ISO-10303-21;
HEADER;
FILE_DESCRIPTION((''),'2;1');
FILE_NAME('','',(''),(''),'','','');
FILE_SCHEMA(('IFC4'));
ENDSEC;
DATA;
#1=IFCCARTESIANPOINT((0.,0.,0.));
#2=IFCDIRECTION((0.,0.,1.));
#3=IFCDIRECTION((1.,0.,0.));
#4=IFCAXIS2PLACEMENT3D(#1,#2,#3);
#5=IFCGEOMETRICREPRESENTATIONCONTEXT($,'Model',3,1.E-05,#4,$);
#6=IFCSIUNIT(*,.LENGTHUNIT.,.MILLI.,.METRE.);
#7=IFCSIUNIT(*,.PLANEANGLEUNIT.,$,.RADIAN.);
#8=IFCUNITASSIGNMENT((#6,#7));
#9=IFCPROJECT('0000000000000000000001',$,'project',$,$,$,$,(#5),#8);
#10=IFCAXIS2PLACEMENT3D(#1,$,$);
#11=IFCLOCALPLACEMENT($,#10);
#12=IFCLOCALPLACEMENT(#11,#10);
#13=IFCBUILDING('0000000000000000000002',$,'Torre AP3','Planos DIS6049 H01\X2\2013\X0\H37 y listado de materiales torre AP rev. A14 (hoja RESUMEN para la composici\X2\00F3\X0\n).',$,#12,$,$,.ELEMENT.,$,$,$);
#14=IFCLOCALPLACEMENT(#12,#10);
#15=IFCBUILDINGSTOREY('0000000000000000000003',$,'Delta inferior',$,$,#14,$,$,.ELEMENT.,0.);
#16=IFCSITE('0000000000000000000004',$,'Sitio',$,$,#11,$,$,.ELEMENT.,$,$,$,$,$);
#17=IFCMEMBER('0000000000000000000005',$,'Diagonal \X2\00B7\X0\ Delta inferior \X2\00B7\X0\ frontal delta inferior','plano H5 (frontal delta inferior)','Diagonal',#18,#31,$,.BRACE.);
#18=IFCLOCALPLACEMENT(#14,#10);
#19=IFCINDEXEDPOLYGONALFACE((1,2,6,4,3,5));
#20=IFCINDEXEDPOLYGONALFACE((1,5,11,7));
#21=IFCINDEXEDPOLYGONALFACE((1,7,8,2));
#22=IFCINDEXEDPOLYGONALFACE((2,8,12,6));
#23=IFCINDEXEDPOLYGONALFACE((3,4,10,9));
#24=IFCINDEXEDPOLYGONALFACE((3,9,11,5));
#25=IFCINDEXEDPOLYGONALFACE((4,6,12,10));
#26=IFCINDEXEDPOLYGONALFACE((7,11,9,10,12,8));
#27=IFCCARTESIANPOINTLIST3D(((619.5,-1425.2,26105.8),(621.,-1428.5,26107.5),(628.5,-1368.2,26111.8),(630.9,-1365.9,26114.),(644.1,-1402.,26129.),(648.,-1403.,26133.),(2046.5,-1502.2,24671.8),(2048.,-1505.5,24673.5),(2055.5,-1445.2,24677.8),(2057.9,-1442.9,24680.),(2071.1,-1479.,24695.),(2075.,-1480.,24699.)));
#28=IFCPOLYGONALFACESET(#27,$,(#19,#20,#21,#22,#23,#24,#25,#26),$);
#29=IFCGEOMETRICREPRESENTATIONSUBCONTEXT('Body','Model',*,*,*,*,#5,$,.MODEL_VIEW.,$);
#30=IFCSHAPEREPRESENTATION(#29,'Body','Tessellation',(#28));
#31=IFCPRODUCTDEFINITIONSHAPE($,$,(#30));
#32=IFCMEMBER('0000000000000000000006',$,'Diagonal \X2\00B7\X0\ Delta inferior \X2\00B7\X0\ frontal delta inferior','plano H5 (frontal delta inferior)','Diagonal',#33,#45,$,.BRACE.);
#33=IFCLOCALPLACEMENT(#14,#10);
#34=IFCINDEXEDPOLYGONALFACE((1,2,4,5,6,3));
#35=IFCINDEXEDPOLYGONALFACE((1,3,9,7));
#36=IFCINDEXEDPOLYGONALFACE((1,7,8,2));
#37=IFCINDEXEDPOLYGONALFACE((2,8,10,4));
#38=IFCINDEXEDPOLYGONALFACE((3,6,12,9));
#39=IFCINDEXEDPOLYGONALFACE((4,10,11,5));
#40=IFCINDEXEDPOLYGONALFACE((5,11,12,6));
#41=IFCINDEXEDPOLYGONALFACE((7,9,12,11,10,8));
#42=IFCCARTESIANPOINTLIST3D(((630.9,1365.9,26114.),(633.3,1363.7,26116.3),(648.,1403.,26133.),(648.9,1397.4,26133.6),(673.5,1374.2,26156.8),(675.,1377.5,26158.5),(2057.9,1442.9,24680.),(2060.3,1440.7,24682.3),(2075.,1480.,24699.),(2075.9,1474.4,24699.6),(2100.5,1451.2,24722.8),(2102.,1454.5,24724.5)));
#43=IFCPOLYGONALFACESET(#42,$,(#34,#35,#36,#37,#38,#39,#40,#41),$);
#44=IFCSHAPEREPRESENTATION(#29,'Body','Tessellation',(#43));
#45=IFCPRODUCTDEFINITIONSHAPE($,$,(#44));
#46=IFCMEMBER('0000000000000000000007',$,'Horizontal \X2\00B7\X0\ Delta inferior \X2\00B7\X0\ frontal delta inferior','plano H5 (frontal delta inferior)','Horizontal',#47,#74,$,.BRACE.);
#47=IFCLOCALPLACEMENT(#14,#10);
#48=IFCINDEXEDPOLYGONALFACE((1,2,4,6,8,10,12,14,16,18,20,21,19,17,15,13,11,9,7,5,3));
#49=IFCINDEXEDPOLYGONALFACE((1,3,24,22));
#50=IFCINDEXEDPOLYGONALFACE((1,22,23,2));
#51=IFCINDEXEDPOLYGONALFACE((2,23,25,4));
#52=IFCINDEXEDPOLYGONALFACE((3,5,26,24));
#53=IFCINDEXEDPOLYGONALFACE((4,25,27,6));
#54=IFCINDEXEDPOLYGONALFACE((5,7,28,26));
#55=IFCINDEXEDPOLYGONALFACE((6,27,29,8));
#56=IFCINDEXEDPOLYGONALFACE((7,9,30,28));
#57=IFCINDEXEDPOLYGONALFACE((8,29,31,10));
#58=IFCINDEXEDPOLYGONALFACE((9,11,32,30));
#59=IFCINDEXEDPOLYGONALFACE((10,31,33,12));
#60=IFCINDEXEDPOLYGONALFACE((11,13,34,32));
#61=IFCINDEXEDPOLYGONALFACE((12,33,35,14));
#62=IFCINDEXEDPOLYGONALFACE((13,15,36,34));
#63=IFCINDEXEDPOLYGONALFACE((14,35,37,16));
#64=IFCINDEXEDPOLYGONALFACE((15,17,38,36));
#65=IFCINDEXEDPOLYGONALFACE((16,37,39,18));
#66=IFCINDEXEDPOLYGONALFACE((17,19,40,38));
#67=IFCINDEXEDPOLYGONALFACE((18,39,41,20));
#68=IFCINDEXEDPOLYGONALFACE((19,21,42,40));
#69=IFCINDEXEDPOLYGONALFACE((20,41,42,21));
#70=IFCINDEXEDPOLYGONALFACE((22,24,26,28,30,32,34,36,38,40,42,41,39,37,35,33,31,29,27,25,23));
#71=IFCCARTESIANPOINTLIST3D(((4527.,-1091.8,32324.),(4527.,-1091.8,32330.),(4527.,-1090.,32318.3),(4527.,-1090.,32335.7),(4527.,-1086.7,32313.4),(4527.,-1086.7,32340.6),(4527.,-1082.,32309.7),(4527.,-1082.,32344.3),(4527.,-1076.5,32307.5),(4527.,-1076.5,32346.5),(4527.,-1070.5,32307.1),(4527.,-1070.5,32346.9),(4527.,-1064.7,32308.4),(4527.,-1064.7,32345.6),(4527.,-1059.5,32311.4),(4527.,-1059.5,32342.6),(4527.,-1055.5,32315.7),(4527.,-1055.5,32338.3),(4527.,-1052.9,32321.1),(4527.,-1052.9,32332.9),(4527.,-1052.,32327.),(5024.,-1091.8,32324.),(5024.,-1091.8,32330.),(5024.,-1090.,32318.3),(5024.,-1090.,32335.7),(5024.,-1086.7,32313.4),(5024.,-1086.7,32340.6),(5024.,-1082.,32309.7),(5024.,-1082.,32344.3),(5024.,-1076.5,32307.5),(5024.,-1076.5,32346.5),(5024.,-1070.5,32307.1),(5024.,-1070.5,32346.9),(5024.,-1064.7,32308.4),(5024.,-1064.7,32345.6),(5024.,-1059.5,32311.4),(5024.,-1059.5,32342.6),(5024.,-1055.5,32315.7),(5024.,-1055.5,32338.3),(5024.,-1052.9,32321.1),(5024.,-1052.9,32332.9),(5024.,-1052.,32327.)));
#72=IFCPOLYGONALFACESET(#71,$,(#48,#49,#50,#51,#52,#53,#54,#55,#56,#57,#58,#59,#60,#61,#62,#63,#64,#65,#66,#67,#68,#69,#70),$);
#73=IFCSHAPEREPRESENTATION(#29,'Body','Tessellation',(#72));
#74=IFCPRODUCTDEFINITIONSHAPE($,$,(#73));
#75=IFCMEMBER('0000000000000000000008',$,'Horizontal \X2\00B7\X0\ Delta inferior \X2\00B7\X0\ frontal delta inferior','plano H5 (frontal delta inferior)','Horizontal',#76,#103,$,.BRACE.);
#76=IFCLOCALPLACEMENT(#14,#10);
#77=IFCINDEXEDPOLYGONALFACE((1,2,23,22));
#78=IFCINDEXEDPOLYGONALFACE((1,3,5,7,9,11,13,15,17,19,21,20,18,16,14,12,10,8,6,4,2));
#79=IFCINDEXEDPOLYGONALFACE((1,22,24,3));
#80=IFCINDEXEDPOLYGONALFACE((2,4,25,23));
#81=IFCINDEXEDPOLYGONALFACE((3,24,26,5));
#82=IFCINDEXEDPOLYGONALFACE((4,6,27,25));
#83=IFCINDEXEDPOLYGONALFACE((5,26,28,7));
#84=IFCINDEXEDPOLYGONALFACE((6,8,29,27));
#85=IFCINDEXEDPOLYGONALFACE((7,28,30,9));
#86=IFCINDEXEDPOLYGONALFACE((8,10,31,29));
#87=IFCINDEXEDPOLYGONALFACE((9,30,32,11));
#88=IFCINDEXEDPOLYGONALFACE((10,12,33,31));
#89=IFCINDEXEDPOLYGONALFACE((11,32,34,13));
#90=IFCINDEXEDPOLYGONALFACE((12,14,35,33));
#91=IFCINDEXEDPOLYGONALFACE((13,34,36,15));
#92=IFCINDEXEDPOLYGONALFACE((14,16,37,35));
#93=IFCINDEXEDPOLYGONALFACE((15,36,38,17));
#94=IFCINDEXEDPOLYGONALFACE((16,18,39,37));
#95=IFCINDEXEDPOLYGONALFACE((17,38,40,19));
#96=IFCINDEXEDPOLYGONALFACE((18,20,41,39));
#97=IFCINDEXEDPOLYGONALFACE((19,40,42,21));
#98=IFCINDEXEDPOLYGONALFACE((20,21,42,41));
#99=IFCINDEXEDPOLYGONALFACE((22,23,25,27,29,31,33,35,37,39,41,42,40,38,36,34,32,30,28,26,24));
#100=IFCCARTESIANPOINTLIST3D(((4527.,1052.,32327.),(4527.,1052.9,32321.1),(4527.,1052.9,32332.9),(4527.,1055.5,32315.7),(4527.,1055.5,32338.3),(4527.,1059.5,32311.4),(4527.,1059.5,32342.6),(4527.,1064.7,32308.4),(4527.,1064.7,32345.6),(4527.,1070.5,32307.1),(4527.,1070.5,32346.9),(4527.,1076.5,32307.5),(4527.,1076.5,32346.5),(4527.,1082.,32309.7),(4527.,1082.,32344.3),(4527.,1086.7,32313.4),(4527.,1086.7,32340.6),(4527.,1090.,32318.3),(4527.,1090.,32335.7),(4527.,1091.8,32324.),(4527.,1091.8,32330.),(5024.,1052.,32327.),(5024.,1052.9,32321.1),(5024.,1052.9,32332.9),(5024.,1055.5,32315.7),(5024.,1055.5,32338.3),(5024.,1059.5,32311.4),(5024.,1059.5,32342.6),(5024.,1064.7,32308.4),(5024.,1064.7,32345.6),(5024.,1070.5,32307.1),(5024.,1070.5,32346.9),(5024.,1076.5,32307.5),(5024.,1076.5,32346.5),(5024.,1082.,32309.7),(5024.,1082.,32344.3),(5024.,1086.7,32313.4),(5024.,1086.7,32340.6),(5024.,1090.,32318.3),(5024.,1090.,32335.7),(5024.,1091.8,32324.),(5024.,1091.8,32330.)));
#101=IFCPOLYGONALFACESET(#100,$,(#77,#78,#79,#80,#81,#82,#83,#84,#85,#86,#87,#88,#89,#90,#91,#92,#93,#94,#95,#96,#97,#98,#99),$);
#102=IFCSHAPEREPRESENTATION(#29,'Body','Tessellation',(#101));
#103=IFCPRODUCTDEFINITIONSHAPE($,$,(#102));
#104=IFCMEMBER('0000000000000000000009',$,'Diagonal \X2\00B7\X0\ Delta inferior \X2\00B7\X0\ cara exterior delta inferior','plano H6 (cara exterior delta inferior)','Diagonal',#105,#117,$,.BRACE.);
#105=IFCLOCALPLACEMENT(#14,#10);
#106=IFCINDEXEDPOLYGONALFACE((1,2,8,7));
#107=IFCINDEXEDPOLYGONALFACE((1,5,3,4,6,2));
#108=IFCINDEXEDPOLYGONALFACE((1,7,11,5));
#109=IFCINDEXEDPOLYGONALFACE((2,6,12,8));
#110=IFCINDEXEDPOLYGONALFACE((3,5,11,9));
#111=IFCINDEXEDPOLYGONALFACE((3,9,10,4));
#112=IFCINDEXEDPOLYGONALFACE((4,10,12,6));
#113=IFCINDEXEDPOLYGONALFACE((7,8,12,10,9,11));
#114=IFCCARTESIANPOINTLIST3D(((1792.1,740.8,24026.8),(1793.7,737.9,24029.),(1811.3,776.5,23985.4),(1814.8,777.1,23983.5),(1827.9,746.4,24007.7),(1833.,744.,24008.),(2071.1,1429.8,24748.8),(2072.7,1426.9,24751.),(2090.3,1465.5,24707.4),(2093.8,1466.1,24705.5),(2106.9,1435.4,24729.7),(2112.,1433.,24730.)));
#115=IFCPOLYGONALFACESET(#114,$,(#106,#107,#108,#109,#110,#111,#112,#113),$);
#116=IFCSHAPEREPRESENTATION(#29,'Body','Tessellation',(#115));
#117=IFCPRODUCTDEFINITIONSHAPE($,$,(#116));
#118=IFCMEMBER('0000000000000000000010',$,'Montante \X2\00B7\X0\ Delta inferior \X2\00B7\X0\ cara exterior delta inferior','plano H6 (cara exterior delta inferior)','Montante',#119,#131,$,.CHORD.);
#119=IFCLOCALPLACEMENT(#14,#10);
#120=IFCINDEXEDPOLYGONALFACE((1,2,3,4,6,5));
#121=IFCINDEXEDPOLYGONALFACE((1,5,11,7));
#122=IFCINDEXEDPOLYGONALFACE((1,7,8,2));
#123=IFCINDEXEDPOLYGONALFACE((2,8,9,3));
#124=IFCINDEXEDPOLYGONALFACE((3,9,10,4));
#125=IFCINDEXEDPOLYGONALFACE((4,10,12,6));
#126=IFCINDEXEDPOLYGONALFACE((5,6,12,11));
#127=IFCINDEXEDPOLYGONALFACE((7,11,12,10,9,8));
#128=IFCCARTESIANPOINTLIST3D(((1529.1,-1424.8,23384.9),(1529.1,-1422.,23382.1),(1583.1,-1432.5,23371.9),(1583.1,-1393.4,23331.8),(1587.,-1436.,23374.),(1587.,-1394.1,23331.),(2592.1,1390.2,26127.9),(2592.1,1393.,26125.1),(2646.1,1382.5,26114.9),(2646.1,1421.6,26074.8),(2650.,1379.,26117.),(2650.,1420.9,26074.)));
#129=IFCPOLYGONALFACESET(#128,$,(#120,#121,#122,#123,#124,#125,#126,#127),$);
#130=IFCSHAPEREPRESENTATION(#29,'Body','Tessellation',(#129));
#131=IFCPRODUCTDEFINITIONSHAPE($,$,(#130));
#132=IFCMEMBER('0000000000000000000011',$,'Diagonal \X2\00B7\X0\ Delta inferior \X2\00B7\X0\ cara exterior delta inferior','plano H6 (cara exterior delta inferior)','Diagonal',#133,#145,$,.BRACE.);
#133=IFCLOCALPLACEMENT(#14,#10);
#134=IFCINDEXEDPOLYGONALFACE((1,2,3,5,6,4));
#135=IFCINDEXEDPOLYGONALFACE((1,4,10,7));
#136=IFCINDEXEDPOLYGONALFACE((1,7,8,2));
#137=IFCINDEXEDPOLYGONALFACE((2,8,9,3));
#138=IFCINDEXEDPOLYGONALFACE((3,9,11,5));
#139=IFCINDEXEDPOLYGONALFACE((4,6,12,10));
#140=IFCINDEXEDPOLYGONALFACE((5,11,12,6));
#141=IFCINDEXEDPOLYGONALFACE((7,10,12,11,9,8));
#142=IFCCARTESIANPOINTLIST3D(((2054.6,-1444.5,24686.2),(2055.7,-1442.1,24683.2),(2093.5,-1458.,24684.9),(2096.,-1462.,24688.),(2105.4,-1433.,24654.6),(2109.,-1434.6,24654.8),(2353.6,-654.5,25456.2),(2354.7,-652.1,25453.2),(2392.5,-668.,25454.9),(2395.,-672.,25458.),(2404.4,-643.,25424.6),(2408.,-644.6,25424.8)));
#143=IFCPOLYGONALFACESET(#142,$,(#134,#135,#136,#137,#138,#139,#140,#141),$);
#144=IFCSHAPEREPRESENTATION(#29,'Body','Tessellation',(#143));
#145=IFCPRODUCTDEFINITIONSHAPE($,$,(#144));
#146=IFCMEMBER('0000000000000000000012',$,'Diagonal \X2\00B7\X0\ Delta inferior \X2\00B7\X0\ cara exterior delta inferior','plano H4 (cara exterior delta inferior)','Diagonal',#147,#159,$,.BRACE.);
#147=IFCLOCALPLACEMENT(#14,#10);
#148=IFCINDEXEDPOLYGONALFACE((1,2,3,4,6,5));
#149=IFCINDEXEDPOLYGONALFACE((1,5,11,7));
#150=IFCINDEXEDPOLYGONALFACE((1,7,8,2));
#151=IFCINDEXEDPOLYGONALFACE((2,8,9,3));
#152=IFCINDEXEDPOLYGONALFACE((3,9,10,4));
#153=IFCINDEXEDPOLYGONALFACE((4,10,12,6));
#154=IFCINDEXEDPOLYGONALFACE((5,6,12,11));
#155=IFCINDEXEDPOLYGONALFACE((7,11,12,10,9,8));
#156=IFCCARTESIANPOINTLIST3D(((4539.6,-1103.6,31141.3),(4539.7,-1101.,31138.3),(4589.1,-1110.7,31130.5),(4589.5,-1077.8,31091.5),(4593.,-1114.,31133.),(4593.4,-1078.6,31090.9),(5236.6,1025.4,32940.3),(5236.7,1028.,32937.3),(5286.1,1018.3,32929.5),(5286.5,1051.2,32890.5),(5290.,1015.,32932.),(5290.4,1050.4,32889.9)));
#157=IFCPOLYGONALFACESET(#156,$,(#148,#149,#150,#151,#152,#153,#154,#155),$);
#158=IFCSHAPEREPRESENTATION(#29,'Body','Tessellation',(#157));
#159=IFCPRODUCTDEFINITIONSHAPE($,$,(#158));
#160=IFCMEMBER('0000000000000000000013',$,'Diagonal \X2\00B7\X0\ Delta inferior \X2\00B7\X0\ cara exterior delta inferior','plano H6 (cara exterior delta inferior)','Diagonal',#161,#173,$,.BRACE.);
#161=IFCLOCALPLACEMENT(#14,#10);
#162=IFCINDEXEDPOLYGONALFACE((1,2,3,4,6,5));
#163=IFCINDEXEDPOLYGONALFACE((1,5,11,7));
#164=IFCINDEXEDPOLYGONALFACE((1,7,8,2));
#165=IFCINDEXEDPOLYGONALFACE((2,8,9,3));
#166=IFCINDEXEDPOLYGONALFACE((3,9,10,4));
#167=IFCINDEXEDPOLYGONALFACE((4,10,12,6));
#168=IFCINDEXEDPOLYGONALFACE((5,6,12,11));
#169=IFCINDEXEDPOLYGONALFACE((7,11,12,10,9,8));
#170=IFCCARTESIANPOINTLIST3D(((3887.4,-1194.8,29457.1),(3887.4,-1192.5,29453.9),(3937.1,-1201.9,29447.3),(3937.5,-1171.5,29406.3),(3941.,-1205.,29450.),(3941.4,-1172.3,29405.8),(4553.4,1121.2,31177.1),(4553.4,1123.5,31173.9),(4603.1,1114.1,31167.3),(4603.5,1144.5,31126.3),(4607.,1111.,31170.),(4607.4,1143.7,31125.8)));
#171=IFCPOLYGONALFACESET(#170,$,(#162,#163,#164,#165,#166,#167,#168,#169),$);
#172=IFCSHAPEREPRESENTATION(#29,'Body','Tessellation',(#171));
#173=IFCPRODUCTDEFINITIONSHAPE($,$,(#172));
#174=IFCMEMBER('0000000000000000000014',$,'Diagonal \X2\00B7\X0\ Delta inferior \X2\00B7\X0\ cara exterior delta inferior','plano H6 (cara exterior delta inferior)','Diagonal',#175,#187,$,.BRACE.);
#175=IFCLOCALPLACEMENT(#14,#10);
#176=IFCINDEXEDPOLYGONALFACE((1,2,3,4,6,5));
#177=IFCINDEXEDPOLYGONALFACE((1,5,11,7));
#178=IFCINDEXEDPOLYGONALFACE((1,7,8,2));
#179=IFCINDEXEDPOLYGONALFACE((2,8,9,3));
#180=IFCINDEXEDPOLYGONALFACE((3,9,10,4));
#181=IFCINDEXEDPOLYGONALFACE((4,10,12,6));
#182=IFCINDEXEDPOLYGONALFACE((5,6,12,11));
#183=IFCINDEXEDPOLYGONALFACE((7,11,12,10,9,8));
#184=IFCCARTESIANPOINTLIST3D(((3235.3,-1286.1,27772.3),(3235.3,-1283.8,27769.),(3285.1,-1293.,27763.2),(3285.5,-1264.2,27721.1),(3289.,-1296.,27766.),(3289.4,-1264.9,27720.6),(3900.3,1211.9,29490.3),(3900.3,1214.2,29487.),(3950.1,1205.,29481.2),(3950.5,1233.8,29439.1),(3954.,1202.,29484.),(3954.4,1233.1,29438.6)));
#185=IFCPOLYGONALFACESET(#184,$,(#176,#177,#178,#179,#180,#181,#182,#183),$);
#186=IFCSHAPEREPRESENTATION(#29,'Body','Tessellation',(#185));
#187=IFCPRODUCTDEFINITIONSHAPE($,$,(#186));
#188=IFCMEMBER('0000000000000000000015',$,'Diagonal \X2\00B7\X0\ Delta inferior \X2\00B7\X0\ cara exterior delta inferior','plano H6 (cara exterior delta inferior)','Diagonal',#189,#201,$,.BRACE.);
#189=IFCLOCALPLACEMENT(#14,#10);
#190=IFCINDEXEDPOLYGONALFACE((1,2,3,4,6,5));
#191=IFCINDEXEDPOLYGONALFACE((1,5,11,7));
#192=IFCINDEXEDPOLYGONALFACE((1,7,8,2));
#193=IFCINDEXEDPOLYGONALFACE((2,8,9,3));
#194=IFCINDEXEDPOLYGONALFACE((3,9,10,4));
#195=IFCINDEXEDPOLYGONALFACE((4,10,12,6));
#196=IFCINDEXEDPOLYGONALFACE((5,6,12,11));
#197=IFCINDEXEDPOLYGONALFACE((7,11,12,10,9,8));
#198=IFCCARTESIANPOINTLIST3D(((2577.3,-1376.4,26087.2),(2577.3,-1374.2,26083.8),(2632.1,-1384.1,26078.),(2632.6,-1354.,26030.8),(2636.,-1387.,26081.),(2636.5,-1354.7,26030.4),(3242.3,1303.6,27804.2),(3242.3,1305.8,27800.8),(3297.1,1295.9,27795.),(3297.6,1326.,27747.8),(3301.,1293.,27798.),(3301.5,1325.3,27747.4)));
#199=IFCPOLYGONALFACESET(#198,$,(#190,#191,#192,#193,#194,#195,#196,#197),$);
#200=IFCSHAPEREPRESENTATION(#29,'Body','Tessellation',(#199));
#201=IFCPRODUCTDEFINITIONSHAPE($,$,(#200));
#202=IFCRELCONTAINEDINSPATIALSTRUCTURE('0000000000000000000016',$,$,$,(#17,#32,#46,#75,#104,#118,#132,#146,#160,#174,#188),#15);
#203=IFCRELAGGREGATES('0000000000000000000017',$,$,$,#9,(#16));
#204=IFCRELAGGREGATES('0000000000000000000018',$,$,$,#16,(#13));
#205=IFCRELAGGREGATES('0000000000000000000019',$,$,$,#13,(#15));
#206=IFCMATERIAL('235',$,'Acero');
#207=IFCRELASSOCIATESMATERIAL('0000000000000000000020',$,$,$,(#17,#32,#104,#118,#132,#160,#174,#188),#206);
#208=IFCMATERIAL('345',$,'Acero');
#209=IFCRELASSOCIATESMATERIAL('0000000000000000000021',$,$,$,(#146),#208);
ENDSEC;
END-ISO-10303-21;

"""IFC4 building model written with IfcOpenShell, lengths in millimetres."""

from ifc_helpers import new_model, si_unit, frame, frame_2d, origin, origin_with_axes, place, context, subcontext, project, spatial, circle, l_section, extrude, material, element, save


model = new_model("IFC4")

# Units and contexts
model_context = context("Model", 3, precision=1e-05, world=origin_with_axes())
body_context = subcontext(model_context, "Body", "Model", "MODEL_VIEW")
ifc_project = project(units=[si_unit("LENGTHUNIT", "METRE", prefix="MILLI"), si_unit("PLANEANGLEUNIT", "RADIAN")], contexts=[model_context])

# Site, building, storey
site_placement = place(None, origin())
site = spatial("IfcSite", under=ifc_project, at=site_placement, Name="Sitio", CompositionType="ELEMENT")
building_placement = place(site_placement, origin())
building = spatial("IfcBuilding", under=site, at=building_placement, Name="Torre AP3", Description="Planos DIS6049 H01–H37 y listado de materiales torre AP rev. A14 (hoja RESUMEN para la composición).", CompositionType="ELEMENT")
storey_placement = place(building_placement, origin())
storey = spatial("IfcBuildingStorey", under=building, at=storey_placement, Name="Delta inferior", CompositionType="ELEMENT", Elevation=0.0)

# Members
ifc_material_1 = material(Name="235", Category="Acero")
for number, where, z_axis, x_axis, name in (
    (1, (2075.0, -1480.0, 24699.0), (-0.704864, 0.038034, 0.708322), (-0.379432, 0.82348, -0.421797), "Diagonal · Delta inferior · frontal delta inferior"),
    (2, (2075.0, 1480.0, 24699.0), (-0.704864, -0.038034, 0.708322), (-0.379432, -0.82348, -0.421797), "Diagonal · Delta inferior · frontal delta inferior"),
):
    element("IfcMember", number, at=place(storey_placement, frame(where, z_axis=z_axis, x_axis=x_axis)), inside=storey, material=ifc_material_1, Name=name, Description="plano H5 (frontal delta inferior)", ObjectType="Diagonal", PredefinedType="BRACE", context=body_context, shape_type="SweptSolid", body=[
        extrude(l_section(Depth=45.0, Width=45.0, Thickness=4.0, at=frame_2d((22.5, 22.5))), None, (0.0, 0.0, 1.0), 2024.5),
    ])
for number, where, z_axis, x_axis, name in (
    (3, (5024.0, -1072.0, 32327.0), (-1.0, 0.0, 0.0), (0.0, 1.0, 0.0), "Horizontal · Delta inferior · frontal delta inferior"),
    (4, (5024.0, 1072.0, 32327.0), (-1.0, 0.0, 0.0), (0.0, -1.0, 0.0), "Horizontal · Delta inferior · frontal delta inferior"),
):
    element("IfcMember", number, at=place(storey_placement, frame(where, z_axis=z_axis, x_axis=x_axis)), inside=storey, Name=name, Description="plano H5 (frontal delta inferior)", ObjectType="Horizontal", PredefinedType="BRACE", context=body_context, shape_type="SweptSolid", body=[
        extrude(circle(Radius=20.0), None, (0.0, 0.0, 1.0), 497.0),
    ])
member_1_placement = place(storey_placement, frame((2112.0, 1433.0, 24730.0), z_axis=(-0.269236, -0.664888, -0.696733), x_axis=(-0.873631, -0.135855, 0.46724)))
element("IfcMember", 5, at=member_1_placement, inside=storey, material=ifc_material_1, Name="Diagonal · Delta inferior · cara exterior delta inferior", Description="plano H6 (cara exterior delta inferior)", ObjectType="Diagonal", PredefinedType="BRACE", context=body_context, shape_type="SweptSolid", body=[
    extrude(l_section(Depth=45.0, Width=45.0, Thickness=4.0, at=frame_2d((22.5, 22.5))), None, (0.0, 0.0, 1.0), 1036.3),
])
member_2_placement = place(storey_placement, frame((2650.0, 1379.0, 26117.0), z_axis=(-0.261074, -0.691368, -0.673685), x_axis=(-0.965319, 0.186983, 0.182201)))
element("IfcMember", 6, at=member_2_placement, inside=storey, material=ifc_material_1, Name="Montante · Delta inferior · cara exterior delta inferior", Description="plano H6 (cara exterior delta inferior)", ObjectType="Montante", PredefinedType="CHORD", context=body_context, shape_type="SweptSolid", body=[
    extrude(l_section(Depth=60.0, Width=60.0, Thickness=4.0, at=frame_2d((30.0, 30.0))), None, (0.0, 0.0, 1.0), 4071.6),
])
member_3_placement = place(storey_placement, frame((2395.0, -672.0, 25458.0), z_axis=(-0.261597, -0.691176, -0.673678), x_axis=(-0.920687, 0.38817, -0.040739)))
element("IfcMember", 7, at=member_3_placement, inside=storey, material=ifc_material_1, Name="Diagonal · Delta inferior · cara exterior delta inferior", Description="plano H6 (cara exterior delta inferior)", ObjectType="Diagonal", PredefinedType="BRACE", context=body_context, shape_type="SweptSolid", body=[
    extrude(l_section(Depth=45.0, Width=45.0, Thickness=4.0, at=frame_2d((22.5, 22.5))), None, (0.0, 0.0, 1.0), 1143.0),
])
ifc_material_2 = material(Name="345", Category="Acero")
member_4_placement = place(storey_placement, frame((5290.0, 1015.0, 32932.0), z_axis=(-0.242593, -0.741005, -0.626147), x_axis=(-0.970107, 0.189587, 0.151492)))
element("IfcMember", 8, at=member_4_placement, inside=storey, material=ifc_material_2, Name="Diagonal · Delta inferior · cara exterior delta inferior", Description="plano H4 (cara exterior delta inferior)", ObjectType="Diagonal", PredefinedType="BRACE", context=body_context, shape_type="SweptSolid", body=[
    extrude(l_section(Depth=55.0, Width=55.0, Thickness=4.0, at=frame_2d((27.5, 27.5))), None, (0.0, 0.0, 1.0), 2873.1),
])
member_5_placement = place(storey_placement, frame((4607.0, 1111.0, 31170.0), z_axis=(-0.224946, -0.782244, -0.580941), x_axis=(-0.974349, 0.184591, 0.128724)))
element("IfcMember", 9, at=member_5_placement, inside=storey, material=ifc_material_1, Name="Diagonal · Delta inferior · cara exterior delta inferior", Description="plano H6 (cara exterior delta inferior)", ObjectType="Diagonal", PredefinedType="BRACE", context=body_context, shape_type="SweptSolid", body=[
    extrude(l_section(Depth=55.0, Width=55.0, Thickness=4.0, at=frame_2d((27.5, 27.5))), None, (0.0, 0.0, 1.0), 2960.7),
])
member_6_placement = place(storey_placement, frame((3954.0, 1202.0, 29484.0), z_axis=(-0.214252, -0.804812, -0.55351), x_axis=(-0.976751, 0.180783, 0.115217)))
element("IfcMember", 10, at=member_6_placement, inside=storey, material=ifc_material_1, Name="Diagonal · Delta inferior · cara exterior delta inferior", Description="plano H6 (cara exterior delta inferior)", ObjectType="Diagonal", PredefinedType="BRACE", context=body_context, shape_type="SweptSolid", body=[
    extrude(l_section(Depth=55.0, Width=55.0, Thickness=4.0, at=frame_2d((27.5, 27.5))), None, (0.0, 0.0, 1.0), 3103.8),
])
member_7_placement = place(storey_placement, frame((3301.0, 1293.0, 27798.0), z_axis=(-0.204517, -0.824217, -0.528052), x_axis=(-0.978826, 0.176893, 0.102997)))
element("IfcMember", 11, at=member_7_placement, inside=storey, material=ifc_material_1, Name="Diagonal · Delta inferior · cara exterior delta inferior", Description="plano H6 (cara exterior delta inferior)", ObjectType="Diagonal", PredefinedType="BRACE", context=body_context, shape_type="SweptSolid", body=[
    extrude(l_section(Depth=60.0, Width=60.0, Thickness=4.0, at=frame_2d((30.0, 30.0))), None, (0.0, 0.0, 1.0), 3251.6),
])

save(model, "model.ifc")
